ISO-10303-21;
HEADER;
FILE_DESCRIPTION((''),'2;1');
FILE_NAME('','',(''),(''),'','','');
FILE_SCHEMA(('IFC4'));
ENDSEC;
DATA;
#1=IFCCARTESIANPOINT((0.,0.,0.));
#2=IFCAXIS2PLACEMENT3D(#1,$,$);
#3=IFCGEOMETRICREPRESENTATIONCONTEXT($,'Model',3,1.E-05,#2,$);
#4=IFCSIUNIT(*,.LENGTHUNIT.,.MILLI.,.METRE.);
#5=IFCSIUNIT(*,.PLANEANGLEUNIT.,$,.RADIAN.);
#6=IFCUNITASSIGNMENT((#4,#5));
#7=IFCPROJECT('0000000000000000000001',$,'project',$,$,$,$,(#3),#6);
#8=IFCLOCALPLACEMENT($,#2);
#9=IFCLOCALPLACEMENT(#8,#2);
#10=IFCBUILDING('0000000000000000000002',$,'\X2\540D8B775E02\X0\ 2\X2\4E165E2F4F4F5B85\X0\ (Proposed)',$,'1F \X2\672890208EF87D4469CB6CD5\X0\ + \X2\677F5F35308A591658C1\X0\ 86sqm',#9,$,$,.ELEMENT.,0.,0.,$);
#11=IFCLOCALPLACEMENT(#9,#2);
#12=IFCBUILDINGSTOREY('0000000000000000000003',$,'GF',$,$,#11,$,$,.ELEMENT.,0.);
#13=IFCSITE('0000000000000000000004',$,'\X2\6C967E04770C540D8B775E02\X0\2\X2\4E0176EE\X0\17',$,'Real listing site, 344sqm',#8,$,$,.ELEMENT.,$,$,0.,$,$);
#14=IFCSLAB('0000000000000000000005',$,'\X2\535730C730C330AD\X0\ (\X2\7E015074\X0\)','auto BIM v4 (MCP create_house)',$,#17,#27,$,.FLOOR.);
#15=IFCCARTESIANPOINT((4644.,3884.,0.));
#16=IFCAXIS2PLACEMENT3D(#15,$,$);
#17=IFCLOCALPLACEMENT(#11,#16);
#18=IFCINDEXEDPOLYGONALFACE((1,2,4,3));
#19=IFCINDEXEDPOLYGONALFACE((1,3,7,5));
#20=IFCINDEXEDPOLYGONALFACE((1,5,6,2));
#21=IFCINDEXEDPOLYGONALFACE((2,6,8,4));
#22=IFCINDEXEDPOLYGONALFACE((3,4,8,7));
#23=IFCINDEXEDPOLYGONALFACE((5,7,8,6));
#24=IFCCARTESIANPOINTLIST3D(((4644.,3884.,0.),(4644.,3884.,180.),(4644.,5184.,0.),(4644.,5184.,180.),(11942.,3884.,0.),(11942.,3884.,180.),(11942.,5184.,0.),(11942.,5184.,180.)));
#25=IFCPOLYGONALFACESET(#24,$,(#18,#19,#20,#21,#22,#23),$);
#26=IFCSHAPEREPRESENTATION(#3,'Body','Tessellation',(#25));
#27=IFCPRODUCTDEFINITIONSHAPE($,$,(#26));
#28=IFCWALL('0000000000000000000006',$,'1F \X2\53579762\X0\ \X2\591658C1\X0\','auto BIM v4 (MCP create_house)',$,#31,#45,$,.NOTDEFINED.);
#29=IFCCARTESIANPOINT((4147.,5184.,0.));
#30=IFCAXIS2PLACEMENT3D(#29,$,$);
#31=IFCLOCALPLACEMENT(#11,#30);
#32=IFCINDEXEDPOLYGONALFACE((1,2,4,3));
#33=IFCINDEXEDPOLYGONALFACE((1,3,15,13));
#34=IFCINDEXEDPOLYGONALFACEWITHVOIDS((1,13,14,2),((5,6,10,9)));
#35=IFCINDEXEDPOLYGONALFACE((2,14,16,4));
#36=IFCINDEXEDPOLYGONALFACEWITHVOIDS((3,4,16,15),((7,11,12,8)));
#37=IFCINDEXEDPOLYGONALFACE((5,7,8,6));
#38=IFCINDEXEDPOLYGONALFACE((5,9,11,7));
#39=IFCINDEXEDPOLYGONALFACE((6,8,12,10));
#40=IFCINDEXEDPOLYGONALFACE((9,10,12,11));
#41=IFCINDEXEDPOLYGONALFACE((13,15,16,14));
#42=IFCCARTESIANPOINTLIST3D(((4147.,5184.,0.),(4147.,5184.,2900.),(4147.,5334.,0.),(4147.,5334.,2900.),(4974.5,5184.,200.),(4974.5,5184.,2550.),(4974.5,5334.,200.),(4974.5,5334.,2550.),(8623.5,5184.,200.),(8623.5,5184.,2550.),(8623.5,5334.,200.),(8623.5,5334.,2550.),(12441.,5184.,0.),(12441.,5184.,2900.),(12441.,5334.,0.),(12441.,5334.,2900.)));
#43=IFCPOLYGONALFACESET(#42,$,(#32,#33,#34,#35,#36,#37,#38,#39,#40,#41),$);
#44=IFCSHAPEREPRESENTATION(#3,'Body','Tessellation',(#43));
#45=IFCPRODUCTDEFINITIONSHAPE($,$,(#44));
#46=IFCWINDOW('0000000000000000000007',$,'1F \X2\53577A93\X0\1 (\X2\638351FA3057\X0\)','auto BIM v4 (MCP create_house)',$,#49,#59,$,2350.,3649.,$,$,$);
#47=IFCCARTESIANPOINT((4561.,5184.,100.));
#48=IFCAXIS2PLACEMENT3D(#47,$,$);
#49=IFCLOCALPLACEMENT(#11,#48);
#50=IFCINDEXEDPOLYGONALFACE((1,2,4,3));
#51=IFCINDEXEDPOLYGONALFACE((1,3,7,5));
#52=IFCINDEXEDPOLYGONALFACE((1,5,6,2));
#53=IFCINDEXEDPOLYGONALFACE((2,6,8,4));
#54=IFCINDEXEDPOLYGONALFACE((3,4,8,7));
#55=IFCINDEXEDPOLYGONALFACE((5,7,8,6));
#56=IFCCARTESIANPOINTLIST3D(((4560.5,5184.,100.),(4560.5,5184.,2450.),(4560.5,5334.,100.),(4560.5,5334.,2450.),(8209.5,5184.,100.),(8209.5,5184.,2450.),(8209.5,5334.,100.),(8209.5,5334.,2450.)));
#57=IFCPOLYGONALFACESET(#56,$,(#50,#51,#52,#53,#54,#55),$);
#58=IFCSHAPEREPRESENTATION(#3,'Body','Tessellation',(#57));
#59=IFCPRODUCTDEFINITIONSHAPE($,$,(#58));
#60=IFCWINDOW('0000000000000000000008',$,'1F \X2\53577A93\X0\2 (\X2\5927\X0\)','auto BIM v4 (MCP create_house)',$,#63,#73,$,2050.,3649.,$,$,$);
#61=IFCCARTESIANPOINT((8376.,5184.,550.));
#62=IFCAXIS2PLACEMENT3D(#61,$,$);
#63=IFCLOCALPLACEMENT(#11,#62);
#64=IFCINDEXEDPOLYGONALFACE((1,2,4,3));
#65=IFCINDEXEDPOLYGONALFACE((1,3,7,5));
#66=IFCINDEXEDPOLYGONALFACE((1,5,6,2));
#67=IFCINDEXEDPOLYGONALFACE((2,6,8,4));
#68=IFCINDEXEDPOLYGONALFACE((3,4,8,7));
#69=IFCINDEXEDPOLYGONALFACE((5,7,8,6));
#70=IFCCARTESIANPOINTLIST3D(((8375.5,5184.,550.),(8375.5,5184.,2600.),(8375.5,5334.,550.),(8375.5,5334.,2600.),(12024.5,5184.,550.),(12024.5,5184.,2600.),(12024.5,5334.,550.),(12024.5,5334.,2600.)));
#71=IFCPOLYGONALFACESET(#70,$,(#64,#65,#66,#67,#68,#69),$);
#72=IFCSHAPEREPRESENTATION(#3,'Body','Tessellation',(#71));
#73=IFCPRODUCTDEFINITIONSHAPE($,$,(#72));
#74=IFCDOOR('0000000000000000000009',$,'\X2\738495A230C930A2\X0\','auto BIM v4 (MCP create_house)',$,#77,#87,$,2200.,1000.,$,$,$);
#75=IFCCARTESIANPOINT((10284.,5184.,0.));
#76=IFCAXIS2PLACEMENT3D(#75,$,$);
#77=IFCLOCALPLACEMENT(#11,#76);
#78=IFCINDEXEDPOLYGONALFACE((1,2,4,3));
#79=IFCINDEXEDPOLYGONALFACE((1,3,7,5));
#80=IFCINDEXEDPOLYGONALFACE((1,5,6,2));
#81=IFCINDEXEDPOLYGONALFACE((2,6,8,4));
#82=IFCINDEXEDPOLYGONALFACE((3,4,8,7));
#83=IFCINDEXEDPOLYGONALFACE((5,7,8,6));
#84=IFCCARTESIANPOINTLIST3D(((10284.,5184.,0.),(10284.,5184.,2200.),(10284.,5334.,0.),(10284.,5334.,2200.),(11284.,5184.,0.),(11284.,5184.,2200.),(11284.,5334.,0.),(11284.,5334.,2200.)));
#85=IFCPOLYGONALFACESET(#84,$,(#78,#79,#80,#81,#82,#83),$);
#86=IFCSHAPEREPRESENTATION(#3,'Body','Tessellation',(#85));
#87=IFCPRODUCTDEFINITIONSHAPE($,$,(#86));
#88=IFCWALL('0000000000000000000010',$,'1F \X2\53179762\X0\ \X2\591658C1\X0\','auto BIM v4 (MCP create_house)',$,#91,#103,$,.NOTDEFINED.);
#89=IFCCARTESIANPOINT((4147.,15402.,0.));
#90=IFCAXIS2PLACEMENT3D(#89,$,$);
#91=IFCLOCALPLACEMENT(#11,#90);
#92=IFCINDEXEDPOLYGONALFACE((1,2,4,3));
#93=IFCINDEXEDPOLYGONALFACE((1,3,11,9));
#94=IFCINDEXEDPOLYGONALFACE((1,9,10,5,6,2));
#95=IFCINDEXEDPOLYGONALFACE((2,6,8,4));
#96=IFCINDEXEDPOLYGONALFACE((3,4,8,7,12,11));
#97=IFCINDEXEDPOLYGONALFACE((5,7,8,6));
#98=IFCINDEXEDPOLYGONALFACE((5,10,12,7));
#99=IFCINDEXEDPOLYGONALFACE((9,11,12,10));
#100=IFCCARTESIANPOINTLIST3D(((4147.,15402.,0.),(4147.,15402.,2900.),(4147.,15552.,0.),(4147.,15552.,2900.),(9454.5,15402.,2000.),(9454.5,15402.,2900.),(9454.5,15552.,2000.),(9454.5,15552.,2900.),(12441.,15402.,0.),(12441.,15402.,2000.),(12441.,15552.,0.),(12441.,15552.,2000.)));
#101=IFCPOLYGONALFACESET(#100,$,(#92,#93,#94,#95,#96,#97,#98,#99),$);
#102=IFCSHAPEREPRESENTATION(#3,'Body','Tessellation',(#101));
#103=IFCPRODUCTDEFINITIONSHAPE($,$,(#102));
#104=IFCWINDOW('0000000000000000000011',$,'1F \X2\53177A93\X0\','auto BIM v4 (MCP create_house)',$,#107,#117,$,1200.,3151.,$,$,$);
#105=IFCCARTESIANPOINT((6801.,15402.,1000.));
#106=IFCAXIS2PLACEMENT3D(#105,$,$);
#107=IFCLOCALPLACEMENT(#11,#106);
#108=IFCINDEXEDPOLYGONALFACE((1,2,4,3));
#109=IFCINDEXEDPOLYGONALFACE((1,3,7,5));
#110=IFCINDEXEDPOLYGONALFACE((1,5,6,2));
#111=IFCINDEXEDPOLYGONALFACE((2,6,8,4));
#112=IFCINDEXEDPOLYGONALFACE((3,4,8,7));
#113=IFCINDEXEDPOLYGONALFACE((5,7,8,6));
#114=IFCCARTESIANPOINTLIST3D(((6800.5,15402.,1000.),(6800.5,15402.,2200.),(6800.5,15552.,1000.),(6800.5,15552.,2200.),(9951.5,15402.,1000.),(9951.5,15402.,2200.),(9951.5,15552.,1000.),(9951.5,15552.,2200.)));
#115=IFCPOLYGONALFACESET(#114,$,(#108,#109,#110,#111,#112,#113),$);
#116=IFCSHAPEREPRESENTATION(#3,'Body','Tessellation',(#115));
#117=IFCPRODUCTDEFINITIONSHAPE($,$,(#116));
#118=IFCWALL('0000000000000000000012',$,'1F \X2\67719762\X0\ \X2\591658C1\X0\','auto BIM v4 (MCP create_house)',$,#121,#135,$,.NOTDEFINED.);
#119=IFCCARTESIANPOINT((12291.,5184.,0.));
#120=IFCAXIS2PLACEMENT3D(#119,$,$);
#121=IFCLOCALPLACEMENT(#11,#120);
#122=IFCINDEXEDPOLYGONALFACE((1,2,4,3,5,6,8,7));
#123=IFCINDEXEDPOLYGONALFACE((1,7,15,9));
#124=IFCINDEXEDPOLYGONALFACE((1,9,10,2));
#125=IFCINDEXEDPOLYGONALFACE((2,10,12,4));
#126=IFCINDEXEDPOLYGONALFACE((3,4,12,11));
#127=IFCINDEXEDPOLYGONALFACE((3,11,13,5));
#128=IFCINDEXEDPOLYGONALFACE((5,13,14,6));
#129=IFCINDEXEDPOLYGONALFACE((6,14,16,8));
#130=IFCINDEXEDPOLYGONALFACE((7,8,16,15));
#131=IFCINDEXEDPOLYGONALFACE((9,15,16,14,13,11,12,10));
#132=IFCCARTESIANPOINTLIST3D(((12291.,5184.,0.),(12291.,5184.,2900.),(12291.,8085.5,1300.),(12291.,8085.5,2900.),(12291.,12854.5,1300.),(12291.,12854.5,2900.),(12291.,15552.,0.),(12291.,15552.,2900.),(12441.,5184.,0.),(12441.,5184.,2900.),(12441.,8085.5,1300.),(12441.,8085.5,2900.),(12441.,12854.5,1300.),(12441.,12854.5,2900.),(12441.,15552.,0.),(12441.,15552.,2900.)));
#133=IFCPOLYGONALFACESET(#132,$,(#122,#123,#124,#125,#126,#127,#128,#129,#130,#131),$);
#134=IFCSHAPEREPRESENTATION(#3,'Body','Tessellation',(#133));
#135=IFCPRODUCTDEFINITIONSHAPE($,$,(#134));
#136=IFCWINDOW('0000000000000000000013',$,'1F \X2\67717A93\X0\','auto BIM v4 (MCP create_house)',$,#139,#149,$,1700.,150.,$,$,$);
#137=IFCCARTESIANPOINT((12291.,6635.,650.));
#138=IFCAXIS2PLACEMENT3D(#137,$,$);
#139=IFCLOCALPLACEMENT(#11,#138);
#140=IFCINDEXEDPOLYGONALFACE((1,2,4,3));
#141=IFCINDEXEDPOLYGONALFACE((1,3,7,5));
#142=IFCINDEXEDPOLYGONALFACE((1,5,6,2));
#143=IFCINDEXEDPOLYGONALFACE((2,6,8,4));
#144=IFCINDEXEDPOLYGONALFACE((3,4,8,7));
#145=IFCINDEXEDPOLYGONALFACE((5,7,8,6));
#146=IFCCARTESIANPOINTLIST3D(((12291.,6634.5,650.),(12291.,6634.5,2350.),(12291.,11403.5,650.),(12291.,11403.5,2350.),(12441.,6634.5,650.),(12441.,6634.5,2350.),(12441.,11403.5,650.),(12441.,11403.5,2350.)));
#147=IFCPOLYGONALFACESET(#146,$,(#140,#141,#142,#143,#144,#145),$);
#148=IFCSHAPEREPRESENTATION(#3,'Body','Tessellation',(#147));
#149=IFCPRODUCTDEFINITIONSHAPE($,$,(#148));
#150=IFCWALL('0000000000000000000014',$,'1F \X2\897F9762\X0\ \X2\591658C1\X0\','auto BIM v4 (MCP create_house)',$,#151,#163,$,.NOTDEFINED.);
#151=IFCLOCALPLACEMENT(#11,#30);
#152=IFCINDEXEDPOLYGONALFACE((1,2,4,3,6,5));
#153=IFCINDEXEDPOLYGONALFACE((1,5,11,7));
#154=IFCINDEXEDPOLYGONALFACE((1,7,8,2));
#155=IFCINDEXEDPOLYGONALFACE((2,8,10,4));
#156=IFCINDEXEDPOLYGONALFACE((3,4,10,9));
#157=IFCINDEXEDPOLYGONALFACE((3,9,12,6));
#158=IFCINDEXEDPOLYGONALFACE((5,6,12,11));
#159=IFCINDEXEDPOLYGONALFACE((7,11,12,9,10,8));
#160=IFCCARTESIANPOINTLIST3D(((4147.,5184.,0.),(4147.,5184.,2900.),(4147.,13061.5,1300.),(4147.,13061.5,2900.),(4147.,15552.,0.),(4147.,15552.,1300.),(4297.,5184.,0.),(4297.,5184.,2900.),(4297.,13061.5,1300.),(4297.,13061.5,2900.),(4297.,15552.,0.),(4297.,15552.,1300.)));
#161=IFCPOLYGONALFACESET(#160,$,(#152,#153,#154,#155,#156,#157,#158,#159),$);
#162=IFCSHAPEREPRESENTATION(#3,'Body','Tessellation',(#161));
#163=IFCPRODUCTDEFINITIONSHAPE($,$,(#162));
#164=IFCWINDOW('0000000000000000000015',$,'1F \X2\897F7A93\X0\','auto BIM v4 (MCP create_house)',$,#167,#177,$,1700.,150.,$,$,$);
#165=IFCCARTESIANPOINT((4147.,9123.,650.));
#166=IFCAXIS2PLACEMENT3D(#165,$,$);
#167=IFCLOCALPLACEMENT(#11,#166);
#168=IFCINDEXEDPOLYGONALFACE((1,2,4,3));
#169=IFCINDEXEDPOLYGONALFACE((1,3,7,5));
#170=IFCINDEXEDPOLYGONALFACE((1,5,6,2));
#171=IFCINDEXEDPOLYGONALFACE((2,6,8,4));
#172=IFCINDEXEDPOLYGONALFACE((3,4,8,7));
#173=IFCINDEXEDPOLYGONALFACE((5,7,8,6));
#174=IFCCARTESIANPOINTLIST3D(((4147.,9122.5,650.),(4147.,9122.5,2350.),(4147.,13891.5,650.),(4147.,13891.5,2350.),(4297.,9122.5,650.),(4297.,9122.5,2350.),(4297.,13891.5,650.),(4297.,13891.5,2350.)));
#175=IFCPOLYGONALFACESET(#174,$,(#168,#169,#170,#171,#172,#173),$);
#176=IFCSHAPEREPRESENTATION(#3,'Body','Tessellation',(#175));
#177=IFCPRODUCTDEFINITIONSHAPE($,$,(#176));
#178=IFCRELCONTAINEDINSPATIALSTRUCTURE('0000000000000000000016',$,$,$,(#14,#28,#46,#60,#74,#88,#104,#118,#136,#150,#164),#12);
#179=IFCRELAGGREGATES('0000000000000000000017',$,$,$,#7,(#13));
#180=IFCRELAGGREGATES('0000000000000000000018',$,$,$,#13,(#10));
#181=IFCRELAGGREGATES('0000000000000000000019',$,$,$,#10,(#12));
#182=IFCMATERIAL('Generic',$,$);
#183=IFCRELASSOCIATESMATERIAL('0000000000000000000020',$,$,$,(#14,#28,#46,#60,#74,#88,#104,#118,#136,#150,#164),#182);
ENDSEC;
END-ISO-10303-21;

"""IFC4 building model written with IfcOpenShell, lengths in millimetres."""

from ifc_helpers import new_model, si_unit, frame, frame_2d, origin, place, context, project, spatial, rectangle, extrude, material, element, fill, save


model = new_model("IFC4")

# Units and contexts
model_context = context("Model", 3, precision=1e-05, world=origin())
ifc_project = project(units=[si_unit("LENGTHUNIT", "METRE", prefix="MILLI"), si_unit("PLANEANGLEUNIT", "RADIAN")], contexts=[model_context])

# Site, building, storey
site_placement = place(None, origin())
site = spatial("IfcSite", under=ifc_project, at=site_placement, Name="沖縄県名護市2丁目17", ObjectType="Real listing site, 344sqm", CompositionType="ELEMENT", RefElevation=0.0)
building_placement = place(site_placement, origin())
building = spatial("IfcBuilding", under=site, at=building_placement, Name="名護市 2世帯住宅 (Proposed)", ObjectType="1F 木造軸組構法 + 板張り外壁 86sqm", CompositionType="ELEMENT", ElevationOfRefHeight=0.0, ElevationOfTerrain=0.0)
storey_placement = place(building_placement, origin())
storey = spatial("IfcBuildingStorey", under=building, at=storey_placement, Name="GF", CompositionType="ELEMENT", Elevation=0.0)

# Slab
ifc_material = material(Name="Generic")
slab_1_placement = place(storey_placement, frame((4644.0, 3884.0, 0.0)))
element("IfcSlab", 1, at=slab_1_placement, inside=storey, material=ifc_material, Name="南デッキ (縁側)", Description="auto BIM v4 (MCP create_house)", PredefinedType="FLOOR", context=model_context, shape_type="SweptSolid", body=[
    extrude(rectangle(XDim=7298.0, YDim=1300.0, at=frame_2d((3649.0, 650.0))), frame((4644.0, 3884.0, 0.0)), (0.0, 0.0, 1.0), 180.0),
])

# Wall, openings, windows, door
wall_1_placement = place(storey_placement, frame((4147.0, 5184.0, 0.0)))
wall_1 = element("IfcWall", 2, at=wall_1_placement, inside=storey, material=ifc_material, Name="1F 南面 外壁", Description="auto BIM v4 (MCP create_house)", PredefinedType="NOTDEFINED", context=model_context, shape_type="SweptSolid", body=[
    extrude(rectangle(XDim=8294.0, YDim=150.0, at=frame_2d((4147.0, 75.0))), frame((4147.0, 5184.0, 0.0)), (0.0, 0.0, 1.0), 2900.0),
])
opening_1_placement = place(storey_placement, frame((4561.0, 5184.0, 100.0)))
opening_1 = element("IfcOpeningElement", 3, at=opening_1_placement, cuts=wall_1, PredefinedType="NOTDEFINED", context=model_context, shape_type="SweptSolid", body=[
    extrude(rectangle(XDim=3649.0, YDim=150.0, at=frame_2d((1824.0, 75.0))), frame((4561.0, 5184.0, 100.0)), (0.0, 0.0, 1.0), 2350.0),
])
opening_2_placement = place(storey_placement, frame((8376.0, 5184.0, 550.0)))
opening_2 = element("IfcOpeningElement", 4, at=opening_2_placement, cuts=wall_1, PredefinedType="NOTDEFINED", context=model_context, shape_type="SweptSolid", body=[
    extrude(rectangle(XDim=3649.0, YDim=150.0, at=frame_2d((1824.0, 75.0))), frame((8376.0, 5184.0, 550.0)), (0.0, 0.0, 1.0), 2050.0),
])
opening_3_placement = place(storey_placement, frame((10284.0, 5184.0, 0.0)))
opening_3 = element("IfcOpeningElement", 5, at=opening_3_placement, cuts=wall_1, PredefinedType="NOTDEFINED", context=model_context, shape_type="SweptSolid", body=[
    extrude(rectangle(XDim=1000.0, YDim=150.0, at=frame_2d((500.0, 75.0))), frame((10284.0, 5184.0, 0.0)), (0.0, 0.0, 1.0), 2200.0),
])
window_1_placement = place(storey_placement, frame((4561.0, 5184.0, 100.0)))
window_1 = element("IfcWindow", 6, at=window_1_placement, inside=storey, material=ifc_material, Name="1F 南窓1 (掃出し)", Description="auto BIM v4 (MCP create_house)", OverallHeight=2350.0, OverallWidth=3649.0, context=model_context, shape_type="SweptSolid", body=[
    extrude(rectangle(XDim=3649.0, YDim=150.0, at=frame_2d((1824.0, 75.0))), frame((4561.0, 5184.0, 100.0)), (0.0, 0.0, 1.0), 2350.0),
])
fill(opening_1, window_1)
window_2_placement = place(storey_placement, frame((8376.0, 5184.0, 550.0)))
window_2 = element("IfcWindow", 7, at=window_2_placement, inside=storey, material=ifc_material, Name="1F 南窓2 (大)", Description="auto BIM v4 (MCP create_house)", OverallHeight=2050.0, OverallWidth=3649.0, context=model_context, shape_type="SweptSolid", body=[
    extrude(rectangle(XDim=3649.0, YDim=150.0, at=frame_2d((1824.0, 75.0))), frame((8376.0, 5184.0, 550.0)), (0.0, 0.0, 1.0), 2050.0),
])
fill(opening_2, window_2)
door_placement = place(storey_placement, frame((10284.0, 5184.0, 0.0)))
door = element("IfcDoor", 8, at=door_placement, inside=storey, material=ifc_material, Name="玄関ドア", Description="auto BIM v4 (MCP create_house)", OverallHeight=2200.0, OverallWidth=1000.0, context=model_context, shape_type="SweptSolid", body=[
    extrude(rectangle(XDim=1000.0, YDim=150.0, at=frame_2d((500.0, 75.0))), frame((10284.0, 5184.0, 0.0)), (0.0, 0.0, 1.0), 2200.0),
])
fill(opening_3, door)

# Walls, openings, windows
wall_2_placement = place(storey_placement, frame((4147.0, 15402.0, 0.0)))
wall_2 = element("IfcWall", 9, at=wall_2_placement, inside=storey, material=ifc_material, Name="1F 北面 外壁", Description="auto BIM v4 (MCP create_house)", PredefinedType="NOTDEFINED", context=model_context, shape_type="SweptSolid", body=[
    extrude(rectangle(XDim=8294.0, YDim=150.0, at=frame_2d((4147.0, 75.0))), frame((4147.0, 15402.0, 0.0)), (0.0, 0.0, 1.0), 2900.0),
])
opening_4_placement = place(storey_placement, frame((6801.0, 15402.0, 1000.0)))
opening_4 = element("IfcOpeningElement", 10, at=opening_4_placement, cuts=wall_2, PredefinedType="NOTDEFINED", context=model_context, shape_type="SweptSolid", body=[
    extrude(rectangle(XDim=3151.0, YDim=150.0, at=frame_2d((1575.0, 75.0))), frame((6801.0, 15402.0, 1000.0)), (0.0, 0.0, 1.0), 1200.0),
])
window_3_placement = place(storey_placement, frame((6801.0, 15402.0, 1000.0)))
window_3 = element("IfcWindow", 11, at=window_3_placement, inside=storey, material=ifc_material, Name="1F 北窓", Description="auto BIM v4 (MCP create_house)", OverallHeight=1200.0, OverallWidth=3151.0, context=model_context, shape_type="SweptSolid", body=[
    extrude(rectangle(XDim=3151.0, YDim=150.0, at=frame_2d((1575.0, 75.0))), frame((6801.0, 15402.0, 1000.0)), (0.0, 0.0, 1.0), 1200.0),
])
fill(opening_4, window_3)
wall_3_placement = place(storey_placement, frame((12291.0, 5184.0, 0.0)))
wall_3 = element("IfcWall", 12, at=wall_3_placement, inside=storey, material=ifc_material, Name="1F 東面 外壁", Description="auto BIM v4 (MCP create_house)", PredefinedType="NOTDEFINED", context=model_context, shape_type="SweptSolid", body=[
    extrude(rectangle(XDim=150.0, YDim=10368.0, at=frame_2d((75.0, 5184.0))), frame((12291.0, 5184.0, 0.0)), (0.0, 0.0, 1.0), 2900.0),
])
opening_5_placement = place(storey_placement, frame((12291.0, 6635.0, 650.0)))
opening_5 = element("IfcOpeningElement", 13, at=opening_5_placement, cuts=wall_3, PredefinedType="NOTDEFINED", context=model_context, shape_type="SweptSolid", body=[
    extrude(rectangle(XDim=150.0, YDim=4769.0, at=frame_2d((75.0, 2384.0))), frame((12291.0, 6635.0, 650.0)), (0.0, 0.0, 1.0), 1700.0),
])
window_4_placement = place(storey_placement, frame((12291.0, 6635.0, 650.0)))
window_4 = element("IfcWindow", 14, at=window_4_placement, inside=storey, material=ifc_material, Name="1F 東窓", Description="auto BIM v4 (MCP create_house)", OverallHeight=1700.0, OverallWidth=150.0, context=model_context, shape_type="SweptSolid", body=[
    extrude(rectangle(XDim=150.0, YDim=4769.0, at=frame_2d((75.0, 2384.0))), frame((12291.0, 6635.0, 650.0)), (0.0, 0.0, 1.0), 1700.0),
])
fill(opening_5, window_4)
wall_4_placement = place(storey_placement, frame((4147.0, 5184.0, 0.0)))
wall_4 = element("IfcWall", 15, at=wall_4_placement, inside=storey, material=ifc_material, Name="1F 西面 外壁", Description="auto BIM v4 (MCP create_house)", PredefinedType="NOTDEFINED", context=model_context, shape_type="SweptSolid", body=[
    extrude(rectangle(XDim=150.0, YDim=10368.0, at=frame_2d((75.0, 5184.0))), frame((4147.0, 5184.0, 0.0)), (0.0, 0.0, 1.0), 2900.0),
])
opening_6_placement = place(storey_placement, frame((4147.0, 9123.0, 650.0)))
opening_6 = element("IfcOpeningElement", 16, at=opening_6_placement, cuts=wall_4, PredefinedType="NOTDEFINED", context=model_context, shape_type="SweptSolid", body=[
    extrude(rectangle(XDim=150.0, YDim=4769.0, at=frame_2d((75.0, 2384.0))), frame((4147.0, 9123.0, 650.0)), (0.0, 0.0, 1.0), 1700.0),
])
window_5_placement = place(storey_placement, frame((4147.0, 9123.0, 650.0)))
window_5 = element("IfcWindow", 17, at=window_5_placement, inside=storey, material=ifc_material, Name="1F 西窓", Description="auto BIM v4 (MCP create_house)", OverallHeight=1700.0, OverallWidth=150.0, context=model_context, shape_type="SweptSolid", body=[
    extrude(rectangle(XDim=150.0, YDim=4769.0, at=frame_2d((75.0, 2384.0))), frame((4147.0, 9123.0, 650.0)), (0.0, 0.0, 1.0), 1700.0),
])
fill(opening_6, window_5)

save(model, "model.ifc")
